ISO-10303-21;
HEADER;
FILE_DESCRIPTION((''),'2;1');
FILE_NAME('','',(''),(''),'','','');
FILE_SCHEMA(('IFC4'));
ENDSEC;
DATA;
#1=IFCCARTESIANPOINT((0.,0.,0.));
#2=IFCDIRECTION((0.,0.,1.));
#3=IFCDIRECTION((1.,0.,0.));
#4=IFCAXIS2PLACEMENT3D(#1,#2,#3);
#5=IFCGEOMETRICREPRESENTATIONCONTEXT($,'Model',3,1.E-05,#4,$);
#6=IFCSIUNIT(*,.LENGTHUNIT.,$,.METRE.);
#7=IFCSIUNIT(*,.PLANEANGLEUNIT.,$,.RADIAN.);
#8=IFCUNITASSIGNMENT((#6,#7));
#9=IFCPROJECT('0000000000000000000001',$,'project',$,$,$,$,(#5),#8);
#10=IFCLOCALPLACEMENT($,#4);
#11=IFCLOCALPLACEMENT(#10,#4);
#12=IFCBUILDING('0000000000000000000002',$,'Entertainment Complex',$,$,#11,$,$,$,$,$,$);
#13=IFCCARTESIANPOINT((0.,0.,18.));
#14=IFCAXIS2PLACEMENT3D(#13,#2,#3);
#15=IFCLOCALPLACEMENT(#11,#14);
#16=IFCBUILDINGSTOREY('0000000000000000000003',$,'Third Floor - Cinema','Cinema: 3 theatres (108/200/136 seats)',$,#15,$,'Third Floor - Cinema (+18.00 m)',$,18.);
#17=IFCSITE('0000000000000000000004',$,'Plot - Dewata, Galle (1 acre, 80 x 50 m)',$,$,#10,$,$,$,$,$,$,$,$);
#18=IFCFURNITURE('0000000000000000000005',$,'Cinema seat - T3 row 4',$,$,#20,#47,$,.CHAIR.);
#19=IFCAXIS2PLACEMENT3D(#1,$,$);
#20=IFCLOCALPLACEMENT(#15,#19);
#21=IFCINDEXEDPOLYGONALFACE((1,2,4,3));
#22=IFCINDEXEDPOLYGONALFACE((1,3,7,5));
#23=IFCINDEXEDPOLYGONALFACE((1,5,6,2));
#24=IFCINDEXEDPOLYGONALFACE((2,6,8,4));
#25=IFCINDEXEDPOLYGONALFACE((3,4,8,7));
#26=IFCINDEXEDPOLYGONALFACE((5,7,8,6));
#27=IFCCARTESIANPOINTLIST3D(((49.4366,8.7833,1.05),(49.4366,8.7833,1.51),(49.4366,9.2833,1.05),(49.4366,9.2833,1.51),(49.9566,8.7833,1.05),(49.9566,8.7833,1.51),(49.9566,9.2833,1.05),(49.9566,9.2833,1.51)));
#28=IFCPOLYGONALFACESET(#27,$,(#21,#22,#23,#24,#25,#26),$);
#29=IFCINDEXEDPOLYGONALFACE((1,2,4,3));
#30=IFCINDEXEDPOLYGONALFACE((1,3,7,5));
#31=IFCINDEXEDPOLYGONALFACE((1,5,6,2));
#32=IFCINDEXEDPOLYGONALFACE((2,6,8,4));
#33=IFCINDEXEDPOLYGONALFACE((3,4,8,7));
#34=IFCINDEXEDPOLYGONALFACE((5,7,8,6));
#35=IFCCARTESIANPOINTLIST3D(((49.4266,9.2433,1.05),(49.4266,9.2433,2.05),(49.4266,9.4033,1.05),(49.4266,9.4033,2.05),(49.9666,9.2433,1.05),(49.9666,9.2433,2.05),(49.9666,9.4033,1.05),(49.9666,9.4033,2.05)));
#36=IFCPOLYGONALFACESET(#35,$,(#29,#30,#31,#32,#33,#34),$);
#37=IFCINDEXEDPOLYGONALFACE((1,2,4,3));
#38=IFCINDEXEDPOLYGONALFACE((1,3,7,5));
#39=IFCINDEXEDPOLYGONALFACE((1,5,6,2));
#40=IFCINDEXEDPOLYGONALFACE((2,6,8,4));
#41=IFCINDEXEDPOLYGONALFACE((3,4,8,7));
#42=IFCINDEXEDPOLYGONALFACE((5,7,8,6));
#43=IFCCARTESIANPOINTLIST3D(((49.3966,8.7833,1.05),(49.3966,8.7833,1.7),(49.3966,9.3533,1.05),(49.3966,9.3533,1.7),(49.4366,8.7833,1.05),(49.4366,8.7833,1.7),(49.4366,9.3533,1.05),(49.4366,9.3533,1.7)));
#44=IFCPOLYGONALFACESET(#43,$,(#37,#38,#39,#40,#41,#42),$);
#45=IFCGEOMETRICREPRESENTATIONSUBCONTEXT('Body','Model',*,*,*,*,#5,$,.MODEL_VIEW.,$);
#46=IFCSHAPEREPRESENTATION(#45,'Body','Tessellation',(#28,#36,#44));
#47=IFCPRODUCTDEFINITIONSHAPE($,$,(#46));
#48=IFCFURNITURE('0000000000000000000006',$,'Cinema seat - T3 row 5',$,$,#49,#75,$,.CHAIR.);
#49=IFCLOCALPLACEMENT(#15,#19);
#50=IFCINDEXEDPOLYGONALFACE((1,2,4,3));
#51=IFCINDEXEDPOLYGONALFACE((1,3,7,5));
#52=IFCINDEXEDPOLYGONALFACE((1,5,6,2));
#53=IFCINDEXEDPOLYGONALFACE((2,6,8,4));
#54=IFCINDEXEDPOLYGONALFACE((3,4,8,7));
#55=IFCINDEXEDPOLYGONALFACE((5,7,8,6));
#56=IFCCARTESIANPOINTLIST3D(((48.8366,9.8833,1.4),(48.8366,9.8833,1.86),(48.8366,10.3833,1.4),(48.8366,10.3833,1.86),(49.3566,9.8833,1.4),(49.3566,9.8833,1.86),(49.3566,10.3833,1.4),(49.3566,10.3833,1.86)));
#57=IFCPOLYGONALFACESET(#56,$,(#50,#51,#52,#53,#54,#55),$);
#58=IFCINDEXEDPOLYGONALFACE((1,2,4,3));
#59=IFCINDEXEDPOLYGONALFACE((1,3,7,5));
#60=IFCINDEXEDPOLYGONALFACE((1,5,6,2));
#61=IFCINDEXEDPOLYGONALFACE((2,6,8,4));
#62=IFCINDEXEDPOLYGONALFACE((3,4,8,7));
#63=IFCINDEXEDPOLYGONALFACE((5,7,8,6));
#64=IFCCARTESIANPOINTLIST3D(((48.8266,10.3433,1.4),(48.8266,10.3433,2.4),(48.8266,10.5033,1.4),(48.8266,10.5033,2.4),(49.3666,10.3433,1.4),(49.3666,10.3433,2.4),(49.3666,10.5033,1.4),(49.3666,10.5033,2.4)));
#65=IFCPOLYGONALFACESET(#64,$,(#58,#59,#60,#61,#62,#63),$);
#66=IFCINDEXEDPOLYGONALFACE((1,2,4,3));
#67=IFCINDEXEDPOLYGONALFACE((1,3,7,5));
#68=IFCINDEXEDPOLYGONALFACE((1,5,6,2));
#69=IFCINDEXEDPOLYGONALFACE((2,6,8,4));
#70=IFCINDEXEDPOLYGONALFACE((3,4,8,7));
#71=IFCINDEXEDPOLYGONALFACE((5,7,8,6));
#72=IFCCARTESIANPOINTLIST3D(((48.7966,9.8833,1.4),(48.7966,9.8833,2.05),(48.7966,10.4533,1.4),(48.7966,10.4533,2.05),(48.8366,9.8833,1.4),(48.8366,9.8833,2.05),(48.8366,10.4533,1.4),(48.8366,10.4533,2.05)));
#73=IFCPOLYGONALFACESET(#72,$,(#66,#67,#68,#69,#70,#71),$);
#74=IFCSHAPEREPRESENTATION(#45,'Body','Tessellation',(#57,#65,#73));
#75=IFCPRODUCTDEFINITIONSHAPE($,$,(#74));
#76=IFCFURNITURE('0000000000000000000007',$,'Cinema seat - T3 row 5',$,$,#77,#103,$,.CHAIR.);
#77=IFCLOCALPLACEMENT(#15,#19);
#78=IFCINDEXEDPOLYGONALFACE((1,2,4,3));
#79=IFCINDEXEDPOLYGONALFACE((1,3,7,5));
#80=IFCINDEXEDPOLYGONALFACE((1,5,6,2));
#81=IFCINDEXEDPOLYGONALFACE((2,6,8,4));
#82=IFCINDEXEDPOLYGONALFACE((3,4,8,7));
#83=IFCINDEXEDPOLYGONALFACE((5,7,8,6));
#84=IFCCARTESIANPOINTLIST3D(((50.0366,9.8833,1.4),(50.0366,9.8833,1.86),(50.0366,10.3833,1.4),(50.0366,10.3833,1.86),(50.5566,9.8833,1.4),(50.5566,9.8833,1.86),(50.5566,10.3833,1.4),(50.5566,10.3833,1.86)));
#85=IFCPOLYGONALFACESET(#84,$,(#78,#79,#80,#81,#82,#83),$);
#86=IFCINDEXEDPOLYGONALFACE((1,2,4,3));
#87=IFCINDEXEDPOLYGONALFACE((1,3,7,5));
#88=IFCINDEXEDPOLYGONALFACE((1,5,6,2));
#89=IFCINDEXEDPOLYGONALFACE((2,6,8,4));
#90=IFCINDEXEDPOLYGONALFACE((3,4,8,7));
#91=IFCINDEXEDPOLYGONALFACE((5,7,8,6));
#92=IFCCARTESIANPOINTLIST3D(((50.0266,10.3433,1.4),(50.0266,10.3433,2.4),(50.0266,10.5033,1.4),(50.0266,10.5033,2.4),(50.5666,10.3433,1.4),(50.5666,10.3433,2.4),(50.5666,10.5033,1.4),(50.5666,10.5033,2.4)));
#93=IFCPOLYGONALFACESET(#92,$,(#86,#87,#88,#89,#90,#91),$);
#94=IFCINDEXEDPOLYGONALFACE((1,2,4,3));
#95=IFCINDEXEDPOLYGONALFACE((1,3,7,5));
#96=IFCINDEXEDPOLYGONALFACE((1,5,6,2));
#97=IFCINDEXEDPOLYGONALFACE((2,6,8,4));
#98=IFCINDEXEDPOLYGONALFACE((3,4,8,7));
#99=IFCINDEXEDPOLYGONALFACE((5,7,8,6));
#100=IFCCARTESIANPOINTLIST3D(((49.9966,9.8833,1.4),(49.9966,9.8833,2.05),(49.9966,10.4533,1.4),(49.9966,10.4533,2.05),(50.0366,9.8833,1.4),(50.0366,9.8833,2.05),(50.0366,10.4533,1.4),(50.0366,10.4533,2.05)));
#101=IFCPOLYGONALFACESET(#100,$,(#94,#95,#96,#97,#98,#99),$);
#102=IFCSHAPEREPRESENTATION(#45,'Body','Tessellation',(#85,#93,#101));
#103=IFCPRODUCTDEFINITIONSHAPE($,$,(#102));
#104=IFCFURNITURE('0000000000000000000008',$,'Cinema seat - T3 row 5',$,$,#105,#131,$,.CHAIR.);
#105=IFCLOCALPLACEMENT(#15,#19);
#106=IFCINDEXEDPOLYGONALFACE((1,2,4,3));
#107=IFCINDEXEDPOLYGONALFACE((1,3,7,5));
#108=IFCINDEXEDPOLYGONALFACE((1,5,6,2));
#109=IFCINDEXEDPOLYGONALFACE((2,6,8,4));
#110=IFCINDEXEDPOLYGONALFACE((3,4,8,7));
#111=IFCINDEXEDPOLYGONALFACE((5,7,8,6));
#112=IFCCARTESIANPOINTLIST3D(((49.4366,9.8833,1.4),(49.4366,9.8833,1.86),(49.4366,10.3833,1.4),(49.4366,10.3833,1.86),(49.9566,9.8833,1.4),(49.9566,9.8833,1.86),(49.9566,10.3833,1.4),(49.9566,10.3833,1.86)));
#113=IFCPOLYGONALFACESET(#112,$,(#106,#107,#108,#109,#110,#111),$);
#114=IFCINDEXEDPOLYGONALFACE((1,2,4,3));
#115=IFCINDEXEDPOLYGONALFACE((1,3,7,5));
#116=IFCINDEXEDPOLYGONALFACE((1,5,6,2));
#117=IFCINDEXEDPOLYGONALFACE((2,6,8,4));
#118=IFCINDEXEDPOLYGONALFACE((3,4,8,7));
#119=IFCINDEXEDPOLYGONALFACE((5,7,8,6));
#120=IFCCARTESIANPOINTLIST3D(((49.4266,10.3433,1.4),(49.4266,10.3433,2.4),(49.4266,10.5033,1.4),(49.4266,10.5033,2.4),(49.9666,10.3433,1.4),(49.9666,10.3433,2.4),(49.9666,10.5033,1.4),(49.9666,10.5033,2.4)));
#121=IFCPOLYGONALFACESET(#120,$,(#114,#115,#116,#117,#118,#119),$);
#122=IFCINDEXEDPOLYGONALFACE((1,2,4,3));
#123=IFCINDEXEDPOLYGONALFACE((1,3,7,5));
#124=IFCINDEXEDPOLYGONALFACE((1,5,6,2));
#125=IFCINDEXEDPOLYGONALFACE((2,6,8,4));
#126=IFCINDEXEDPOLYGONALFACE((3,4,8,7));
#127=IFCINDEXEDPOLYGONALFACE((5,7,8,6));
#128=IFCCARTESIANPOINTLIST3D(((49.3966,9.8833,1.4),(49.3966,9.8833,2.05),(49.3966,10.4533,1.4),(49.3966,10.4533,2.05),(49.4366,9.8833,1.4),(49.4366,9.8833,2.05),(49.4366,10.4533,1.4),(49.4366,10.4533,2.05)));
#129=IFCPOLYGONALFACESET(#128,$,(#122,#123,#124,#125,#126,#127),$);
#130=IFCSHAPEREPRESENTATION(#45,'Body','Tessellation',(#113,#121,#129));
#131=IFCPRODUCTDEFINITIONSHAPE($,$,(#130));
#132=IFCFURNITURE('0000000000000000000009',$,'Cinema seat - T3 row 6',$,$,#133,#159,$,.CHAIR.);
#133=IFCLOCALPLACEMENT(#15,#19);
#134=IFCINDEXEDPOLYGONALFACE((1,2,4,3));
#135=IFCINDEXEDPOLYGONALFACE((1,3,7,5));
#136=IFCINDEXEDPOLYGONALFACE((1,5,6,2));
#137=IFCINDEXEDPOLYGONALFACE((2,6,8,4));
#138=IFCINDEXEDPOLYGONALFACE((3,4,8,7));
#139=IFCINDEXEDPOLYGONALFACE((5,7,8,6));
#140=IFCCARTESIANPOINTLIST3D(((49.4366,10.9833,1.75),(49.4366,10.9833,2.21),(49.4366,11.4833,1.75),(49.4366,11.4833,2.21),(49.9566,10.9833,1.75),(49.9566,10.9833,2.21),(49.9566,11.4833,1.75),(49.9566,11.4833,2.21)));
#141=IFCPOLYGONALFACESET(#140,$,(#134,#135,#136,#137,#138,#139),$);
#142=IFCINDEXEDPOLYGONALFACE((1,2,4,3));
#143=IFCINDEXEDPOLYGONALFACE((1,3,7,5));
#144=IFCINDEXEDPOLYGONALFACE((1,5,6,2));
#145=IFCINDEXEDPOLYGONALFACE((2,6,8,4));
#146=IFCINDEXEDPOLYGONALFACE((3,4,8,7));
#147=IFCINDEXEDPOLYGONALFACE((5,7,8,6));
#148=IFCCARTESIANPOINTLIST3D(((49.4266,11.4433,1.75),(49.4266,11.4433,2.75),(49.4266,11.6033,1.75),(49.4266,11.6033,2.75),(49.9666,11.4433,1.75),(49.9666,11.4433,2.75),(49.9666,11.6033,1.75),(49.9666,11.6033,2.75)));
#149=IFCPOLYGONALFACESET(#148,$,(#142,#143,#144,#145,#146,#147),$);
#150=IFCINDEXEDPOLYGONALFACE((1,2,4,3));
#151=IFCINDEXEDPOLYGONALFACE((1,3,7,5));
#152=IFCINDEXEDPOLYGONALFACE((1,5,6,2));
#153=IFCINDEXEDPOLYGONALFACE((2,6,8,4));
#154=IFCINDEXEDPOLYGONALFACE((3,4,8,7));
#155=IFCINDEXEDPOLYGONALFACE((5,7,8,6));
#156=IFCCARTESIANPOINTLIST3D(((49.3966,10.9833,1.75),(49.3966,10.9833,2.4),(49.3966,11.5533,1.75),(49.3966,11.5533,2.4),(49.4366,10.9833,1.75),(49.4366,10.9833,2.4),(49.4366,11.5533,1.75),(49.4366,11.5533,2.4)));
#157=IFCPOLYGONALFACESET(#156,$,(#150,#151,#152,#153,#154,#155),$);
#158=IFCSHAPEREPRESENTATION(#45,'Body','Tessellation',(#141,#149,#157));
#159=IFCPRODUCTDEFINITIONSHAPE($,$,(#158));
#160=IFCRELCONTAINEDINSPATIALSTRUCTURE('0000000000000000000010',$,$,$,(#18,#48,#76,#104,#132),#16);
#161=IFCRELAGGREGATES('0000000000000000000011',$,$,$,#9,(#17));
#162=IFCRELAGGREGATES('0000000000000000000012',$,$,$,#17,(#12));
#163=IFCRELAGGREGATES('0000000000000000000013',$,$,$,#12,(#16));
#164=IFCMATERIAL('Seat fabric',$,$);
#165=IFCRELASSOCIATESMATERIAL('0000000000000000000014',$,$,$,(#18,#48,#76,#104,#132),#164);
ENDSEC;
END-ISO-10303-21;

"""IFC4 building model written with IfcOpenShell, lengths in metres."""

from ifc_helpers import new_model, si_unit, frame, origin_with_axes, place, context, subcontext, project, spatial, polyline, outline, extrude, material, element, save


model = new_model("IFC4")

# Units and contexts
model_context = context("Model", 3, precision=1e-05, world=origin_with_axes())
body_context = subcontext(model_context, "Body", "Model", "MODEL_VIEW")
ifc_project = project(units=[si_unit("LENGTHUNIT", "METRE"), si_unit("PLANEANGLEUNIT", "RADIAN")], contexts=[model_context])

# Site, building, storey
site_placement = place(None, origin_with_axes())
site = spatial("IfcSite", under=ifc_project, at=site_placement, Name="Plot - Dewata, Galle (1 acre, 80 x 50 m)")
building_placement = place(site_placement, origin_with_axes())
building = spatial("IfcBuilding", under=site, at=building_placement, Name="Entertainment Complex")
storey_placement = place(building_placement, frame((0.0, 0.0, 18.0), z_axis=(0.0, 0.0, 1.0), x_axis=(1.0, 0.0, 0.0)))
storey = spatial("IfcBuildingStorey", under=building, at=storey_placement, Name="Third Floor - Cinema", Description="Cinema: 3 theatres (108/200/136 seats)", LongName="Third Floor - Cinema (+18.00 m)", Elevation=18.0)

# Furniture
ifc_material_1 = material(Name="Seat fabric")
for number, where, z_axis, x_axis, name in (
    (1, (49.6966, 9.4033, 1.05), (0.0, 0.0, 1.0), (0.0, 1.0, 0.0), "Cinema seat - T3 row 4"),
    (2, (49.0966, 10.5033, 1.4), (0.0, 0.0, 1.0), (0.0, 1.0, 0.0), "Cinema seat - T3 row 5"),
    (3, (50.2966, 10.5033, 1.4), (0.0, 0.0, 1.0), (0.0, 1.0, 0.0), "Cinema seat - T3 row 5"),
    (4, (49.6966, 10.5033, 1.4), (0.0, 0.0, 1.0), (0.0, 1.0, 0.0), "Cinema seat - T3 row 5"),
    (5, (49.6966, 11.6033, 1.75), (0.0, 0.0, 1.0), (0.0, 1.0, 0.0), "Cinema seat - T3 row 6"),
):
    element("IfcFurniture", number, at=place(storey_placement, frame(where, z_axis=z_axis, x_axis=x_axis)), inside=storey, material=ifc_material_1, Name=name, PredefinedType="CHAIR", context=body_context, shape_type="SweptSolid", body=[
        extrude(outline(polyline([(-0.62, -0.26), (-0.12, -0.26), (-0.12, 0.26), (-0.62, 0.26), (-0.62, -0.26)])), origin_with_axes(), (0.0, 0.0, 1.0), 0.46),
        extrude(outline(polyline([(-0.16, -0.27), (0.0, -0.27), (0.0, 0.27), (-0.16, 0.27), (-0.16, -0.27)])), origin_with_axes(), (0.0, 0.0, 1.0), 1.0),
        extrude(outline(polyline([(-0.62, 0.26), (-0.05, 0.26), (-0.05, 0.3), (-0.62, 0.3), (-0.62, 0.26)])), origin_with_axes(), (0.0, 0.0, 1.0), 0.65),
    ])

save(model, "model.ifc")
